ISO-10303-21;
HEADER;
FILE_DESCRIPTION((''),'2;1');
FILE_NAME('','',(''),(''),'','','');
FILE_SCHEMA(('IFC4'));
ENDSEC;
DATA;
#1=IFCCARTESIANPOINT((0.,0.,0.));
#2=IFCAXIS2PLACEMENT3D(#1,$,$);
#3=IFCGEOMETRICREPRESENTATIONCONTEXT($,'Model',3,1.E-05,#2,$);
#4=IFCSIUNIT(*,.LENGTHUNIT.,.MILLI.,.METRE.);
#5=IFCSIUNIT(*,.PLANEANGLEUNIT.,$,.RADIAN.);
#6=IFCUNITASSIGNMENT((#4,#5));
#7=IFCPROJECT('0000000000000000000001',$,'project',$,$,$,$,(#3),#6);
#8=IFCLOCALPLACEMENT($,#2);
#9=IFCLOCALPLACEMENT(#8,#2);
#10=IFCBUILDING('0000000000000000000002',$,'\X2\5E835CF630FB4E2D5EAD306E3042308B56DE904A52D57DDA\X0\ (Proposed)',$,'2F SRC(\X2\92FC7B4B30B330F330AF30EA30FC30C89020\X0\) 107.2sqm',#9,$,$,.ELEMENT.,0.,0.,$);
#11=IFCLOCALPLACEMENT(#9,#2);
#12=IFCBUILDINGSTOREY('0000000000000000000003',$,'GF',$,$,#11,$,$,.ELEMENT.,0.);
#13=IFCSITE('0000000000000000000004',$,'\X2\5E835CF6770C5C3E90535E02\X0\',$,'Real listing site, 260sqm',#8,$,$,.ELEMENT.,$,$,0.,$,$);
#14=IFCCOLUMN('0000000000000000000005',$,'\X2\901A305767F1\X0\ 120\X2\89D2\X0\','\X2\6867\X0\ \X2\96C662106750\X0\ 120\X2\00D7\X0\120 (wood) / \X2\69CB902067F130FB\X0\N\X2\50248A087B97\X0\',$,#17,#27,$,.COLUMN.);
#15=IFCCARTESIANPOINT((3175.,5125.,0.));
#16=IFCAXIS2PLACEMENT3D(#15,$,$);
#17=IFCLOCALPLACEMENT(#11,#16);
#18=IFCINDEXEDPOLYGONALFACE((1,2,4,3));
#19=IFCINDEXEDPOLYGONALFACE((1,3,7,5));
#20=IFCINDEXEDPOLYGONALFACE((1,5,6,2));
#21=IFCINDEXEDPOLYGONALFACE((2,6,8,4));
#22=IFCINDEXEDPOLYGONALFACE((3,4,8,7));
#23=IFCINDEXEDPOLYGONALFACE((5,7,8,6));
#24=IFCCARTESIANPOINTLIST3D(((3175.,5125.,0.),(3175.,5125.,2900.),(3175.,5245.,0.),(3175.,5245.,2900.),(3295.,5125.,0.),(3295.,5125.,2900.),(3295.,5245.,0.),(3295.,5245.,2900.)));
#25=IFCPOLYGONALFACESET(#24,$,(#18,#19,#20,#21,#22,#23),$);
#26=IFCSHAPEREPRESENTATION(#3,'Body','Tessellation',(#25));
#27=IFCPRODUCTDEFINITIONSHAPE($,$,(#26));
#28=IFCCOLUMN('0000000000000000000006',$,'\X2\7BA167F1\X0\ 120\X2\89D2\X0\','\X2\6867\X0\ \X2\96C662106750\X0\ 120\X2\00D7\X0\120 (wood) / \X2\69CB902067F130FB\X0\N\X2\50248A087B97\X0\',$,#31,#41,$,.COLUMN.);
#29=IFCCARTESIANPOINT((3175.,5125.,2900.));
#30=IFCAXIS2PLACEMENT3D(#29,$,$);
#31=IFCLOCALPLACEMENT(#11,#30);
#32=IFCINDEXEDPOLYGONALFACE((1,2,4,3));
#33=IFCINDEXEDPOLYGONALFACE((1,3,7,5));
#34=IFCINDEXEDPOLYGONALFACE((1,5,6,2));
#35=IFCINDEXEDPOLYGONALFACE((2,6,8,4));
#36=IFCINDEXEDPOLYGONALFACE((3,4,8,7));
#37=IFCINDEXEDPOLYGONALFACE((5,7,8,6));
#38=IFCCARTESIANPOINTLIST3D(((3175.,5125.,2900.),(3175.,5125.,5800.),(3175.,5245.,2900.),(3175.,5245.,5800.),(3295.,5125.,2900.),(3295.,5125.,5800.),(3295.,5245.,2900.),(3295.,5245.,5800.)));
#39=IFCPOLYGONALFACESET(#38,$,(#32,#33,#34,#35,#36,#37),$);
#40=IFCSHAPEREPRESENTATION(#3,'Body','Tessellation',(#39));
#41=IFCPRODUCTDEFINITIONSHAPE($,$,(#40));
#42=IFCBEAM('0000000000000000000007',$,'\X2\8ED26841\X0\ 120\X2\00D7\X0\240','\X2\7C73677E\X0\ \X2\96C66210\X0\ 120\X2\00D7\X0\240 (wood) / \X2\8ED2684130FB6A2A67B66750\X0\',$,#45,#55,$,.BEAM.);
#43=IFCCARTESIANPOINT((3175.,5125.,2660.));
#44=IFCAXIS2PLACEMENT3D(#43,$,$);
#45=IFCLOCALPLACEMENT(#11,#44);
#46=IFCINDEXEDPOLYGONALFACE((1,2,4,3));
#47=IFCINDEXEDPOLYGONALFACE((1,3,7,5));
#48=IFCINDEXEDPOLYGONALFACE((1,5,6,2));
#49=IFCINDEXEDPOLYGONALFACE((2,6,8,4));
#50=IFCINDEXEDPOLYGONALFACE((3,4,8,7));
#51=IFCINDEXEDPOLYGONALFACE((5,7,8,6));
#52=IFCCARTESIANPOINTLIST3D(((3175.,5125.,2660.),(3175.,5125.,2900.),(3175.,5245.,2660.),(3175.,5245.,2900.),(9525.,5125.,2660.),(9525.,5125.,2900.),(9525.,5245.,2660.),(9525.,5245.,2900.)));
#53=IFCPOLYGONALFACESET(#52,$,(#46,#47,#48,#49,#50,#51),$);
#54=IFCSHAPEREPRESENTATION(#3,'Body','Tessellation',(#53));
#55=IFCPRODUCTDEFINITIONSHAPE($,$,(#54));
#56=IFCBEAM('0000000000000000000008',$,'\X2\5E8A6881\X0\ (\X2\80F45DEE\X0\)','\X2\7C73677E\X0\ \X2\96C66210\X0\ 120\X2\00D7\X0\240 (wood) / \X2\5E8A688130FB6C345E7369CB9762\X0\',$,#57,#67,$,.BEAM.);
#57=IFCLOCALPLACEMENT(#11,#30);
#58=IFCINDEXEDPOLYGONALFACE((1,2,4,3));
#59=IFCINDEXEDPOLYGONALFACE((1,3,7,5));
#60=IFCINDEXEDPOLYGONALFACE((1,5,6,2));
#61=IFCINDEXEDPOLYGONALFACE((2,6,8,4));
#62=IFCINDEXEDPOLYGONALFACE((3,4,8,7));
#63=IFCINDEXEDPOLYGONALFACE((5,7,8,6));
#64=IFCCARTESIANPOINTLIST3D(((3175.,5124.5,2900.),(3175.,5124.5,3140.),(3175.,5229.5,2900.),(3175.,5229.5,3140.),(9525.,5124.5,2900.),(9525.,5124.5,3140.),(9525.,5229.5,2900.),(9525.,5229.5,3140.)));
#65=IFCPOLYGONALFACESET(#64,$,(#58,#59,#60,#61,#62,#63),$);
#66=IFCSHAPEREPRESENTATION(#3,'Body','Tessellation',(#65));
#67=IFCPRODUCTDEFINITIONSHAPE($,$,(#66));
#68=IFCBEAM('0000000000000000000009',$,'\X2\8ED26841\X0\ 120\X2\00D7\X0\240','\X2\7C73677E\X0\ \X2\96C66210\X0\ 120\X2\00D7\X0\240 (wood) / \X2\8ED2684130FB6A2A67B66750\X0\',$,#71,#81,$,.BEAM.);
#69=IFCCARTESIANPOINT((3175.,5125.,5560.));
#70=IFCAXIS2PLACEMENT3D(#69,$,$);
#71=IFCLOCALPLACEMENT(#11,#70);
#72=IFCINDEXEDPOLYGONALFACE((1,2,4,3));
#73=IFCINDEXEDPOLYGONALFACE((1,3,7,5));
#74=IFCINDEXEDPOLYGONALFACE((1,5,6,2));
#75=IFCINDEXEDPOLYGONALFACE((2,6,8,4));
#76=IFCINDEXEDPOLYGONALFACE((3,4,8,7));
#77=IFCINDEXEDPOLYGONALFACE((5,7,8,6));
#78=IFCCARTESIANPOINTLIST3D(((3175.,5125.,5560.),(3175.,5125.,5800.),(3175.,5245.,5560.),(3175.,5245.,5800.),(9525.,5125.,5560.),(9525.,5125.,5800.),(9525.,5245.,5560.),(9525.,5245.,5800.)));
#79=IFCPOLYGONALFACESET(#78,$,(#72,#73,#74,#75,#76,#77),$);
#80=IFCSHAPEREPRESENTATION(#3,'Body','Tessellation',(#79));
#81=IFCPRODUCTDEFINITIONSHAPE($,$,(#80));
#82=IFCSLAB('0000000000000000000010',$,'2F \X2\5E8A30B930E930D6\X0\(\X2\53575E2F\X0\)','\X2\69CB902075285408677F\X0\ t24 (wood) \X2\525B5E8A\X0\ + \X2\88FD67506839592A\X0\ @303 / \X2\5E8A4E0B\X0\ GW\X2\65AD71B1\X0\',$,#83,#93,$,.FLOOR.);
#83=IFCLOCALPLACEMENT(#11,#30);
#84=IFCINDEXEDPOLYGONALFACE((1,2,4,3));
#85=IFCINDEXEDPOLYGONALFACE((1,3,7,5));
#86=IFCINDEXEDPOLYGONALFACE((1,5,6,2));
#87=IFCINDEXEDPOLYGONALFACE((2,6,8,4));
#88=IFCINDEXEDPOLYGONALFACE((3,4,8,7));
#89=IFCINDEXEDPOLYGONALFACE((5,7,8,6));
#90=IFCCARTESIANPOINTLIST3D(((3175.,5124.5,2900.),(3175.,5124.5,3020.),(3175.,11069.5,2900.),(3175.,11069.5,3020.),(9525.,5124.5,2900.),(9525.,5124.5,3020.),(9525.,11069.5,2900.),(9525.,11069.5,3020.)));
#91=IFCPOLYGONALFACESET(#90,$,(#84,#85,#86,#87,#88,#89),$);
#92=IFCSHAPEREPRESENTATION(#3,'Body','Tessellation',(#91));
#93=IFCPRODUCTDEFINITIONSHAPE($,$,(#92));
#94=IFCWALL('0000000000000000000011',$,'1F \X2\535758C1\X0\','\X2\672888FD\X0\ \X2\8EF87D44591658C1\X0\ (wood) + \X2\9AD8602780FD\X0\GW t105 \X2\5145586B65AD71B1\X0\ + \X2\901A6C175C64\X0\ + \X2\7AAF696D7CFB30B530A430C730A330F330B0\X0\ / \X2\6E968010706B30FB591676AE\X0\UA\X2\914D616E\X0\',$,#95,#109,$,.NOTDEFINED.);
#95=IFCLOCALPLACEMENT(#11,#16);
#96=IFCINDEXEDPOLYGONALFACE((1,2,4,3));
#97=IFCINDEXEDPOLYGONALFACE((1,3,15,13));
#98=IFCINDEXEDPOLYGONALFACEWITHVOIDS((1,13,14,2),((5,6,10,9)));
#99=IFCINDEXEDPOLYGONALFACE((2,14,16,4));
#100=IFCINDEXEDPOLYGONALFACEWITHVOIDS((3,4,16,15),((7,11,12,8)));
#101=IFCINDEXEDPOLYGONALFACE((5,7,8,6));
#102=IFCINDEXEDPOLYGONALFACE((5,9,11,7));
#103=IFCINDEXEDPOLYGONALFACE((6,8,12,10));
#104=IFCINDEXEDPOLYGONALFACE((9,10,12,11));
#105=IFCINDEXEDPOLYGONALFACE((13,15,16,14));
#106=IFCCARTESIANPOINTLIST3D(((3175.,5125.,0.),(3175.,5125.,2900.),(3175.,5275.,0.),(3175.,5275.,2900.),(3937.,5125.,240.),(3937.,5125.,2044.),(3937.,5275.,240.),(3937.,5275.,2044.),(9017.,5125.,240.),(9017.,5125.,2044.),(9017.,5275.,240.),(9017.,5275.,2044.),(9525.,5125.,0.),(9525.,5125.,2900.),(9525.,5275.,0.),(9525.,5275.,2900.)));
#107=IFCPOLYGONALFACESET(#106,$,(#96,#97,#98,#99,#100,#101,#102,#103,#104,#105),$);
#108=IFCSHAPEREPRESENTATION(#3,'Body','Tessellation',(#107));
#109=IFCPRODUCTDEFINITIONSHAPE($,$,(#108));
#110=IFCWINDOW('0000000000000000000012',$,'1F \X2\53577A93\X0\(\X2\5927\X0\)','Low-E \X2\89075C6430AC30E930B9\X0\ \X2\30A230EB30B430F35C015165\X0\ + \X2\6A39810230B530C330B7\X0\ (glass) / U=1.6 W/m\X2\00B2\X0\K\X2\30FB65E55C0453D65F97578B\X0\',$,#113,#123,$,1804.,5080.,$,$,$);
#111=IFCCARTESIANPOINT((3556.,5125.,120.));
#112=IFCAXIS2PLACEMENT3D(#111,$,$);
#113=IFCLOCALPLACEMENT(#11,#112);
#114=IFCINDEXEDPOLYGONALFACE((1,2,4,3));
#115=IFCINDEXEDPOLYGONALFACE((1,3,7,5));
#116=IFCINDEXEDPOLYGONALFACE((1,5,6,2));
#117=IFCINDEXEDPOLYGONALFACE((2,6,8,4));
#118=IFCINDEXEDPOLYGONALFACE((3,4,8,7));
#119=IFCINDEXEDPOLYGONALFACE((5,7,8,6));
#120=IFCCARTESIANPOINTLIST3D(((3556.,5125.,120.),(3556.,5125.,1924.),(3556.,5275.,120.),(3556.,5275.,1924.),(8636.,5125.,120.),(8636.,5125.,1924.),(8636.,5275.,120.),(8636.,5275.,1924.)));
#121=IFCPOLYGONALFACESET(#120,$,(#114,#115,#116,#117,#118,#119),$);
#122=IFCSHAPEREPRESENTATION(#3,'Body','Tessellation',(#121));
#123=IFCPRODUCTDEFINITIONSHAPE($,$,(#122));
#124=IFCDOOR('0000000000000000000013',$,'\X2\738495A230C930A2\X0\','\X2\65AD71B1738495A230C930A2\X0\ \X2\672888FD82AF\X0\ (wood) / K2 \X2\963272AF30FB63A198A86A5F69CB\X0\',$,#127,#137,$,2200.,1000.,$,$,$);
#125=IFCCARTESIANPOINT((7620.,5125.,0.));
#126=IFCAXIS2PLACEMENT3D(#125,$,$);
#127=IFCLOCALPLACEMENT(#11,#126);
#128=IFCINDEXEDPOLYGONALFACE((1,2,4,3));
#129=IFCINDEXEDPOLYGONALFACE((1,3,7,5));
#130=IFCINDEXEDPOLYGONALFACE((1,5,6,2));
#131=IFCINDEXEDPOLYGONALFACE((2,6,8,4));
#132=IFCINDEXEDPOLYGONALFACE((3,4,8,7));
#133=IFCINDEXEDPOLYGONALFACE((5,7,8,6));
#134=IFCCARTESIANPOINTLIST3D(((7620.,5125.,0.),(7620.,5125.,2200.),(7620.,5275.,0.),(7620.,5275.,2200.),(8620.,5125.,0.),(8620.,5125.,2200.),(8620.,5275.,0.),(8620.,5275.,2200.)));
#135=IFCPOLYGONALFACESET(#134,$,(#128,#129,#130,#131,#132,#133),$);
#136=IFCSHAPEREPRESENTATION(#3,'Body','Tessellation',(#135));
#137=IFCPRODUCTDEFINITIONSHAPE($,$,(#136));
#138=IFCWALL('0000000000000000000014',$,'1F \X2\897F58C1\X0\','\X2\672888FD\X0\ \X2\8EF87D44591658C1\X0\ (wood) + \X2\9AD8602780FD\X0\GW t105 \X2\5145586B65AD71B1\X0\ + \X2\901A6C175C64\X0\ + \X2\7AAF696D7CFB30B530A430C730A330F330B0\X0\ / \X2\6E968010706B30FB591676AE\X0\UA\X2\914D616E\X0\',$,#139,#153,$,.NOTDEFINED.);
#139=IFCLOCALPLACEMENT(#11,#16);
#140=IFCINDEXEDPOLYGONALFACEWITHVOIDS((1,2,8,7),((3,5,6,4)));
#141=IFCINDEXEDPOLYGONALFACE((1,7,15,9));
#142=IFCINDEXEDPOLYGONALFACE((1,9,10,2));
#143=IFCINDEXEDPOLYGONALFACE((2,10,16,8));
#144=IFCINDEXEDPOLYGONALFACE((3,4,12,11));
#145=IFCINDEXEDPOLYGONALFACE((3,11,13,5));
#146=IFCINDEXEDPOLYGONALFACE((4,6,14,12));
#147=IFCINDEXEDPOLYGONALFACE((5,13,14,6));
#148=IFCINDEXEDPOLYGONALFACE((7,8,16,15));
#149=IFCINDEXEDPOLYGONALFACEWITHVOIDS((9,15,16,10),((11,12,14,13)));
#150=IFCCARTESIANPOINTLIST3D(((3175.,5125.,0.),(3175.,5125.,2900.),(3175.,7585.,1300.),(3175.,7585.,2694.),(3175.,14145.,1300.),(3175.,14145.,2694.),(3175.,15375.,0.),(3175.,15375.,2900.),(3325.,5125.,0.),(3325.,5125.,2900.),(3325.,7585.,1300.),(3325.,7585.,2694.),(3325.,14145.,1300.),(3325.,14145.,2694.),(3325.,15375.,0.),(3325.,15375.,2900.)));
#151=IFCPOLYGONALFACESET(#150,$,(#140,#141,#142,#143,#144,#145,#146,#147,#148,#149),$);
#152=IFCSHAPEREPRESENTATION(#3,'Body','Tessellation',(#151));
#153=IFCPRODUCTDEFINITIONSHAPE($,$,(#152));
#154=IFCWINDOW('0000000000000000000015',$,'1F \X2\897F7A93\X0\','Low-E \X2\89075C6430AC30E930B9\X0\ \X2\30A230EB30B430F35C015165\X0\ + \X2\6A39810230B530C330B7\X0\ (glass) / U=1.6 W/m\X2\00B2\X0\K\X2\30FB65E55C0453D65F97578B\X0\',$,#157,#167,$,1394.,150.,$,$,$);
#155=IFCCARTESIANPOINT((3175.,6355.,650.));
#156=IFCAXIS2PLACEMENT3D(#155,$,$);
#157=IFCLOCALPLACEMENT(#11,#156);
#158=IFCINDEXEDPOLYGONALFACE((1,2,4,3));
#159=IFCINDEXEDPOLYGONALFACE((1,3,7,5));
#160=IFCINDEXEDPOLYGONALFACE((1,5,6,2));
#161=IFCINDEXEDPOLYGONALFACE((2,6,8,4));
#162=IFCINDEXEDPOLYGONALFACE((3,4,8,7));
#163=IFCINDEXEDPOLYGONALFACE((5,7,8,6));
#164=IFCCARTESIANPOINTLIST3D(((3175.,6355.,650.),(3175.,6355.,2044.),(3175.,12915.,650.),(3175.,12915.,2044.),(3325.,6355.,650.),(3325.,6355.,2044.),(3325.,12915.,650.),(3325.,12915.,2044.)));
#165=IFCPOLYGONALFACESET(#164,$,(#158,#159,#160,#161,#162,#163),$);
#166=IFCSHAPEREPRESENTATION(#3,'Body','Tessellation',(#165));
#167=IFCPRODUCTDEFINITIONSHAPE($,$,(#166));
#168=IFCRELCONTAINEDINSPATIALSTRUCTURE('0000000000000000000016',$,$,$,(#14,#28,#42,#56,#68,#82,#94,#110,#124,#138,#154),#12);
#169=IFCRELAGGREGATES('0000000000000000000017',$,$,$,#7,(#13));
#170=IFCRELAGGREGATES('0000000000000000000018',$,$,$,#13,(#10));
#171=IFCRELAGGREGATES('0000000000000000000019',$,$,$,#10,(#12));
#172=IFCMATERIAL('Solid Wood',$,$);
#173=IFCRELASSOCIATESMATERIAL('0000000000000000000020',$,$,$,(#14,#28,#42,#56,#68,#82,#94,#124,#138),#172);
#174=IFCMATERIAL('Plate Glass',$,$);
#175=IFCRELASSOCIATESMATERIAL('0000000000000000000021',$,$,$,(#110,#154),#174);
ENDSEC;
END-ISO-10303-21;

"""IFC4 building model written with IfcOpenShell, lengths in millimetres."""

from ifc_helpers import new_model, si_unit, frame, frame_2d, origin, place, context, project, spatial, rectangle, extrude, material, element, fill, save


model = new_model("IFC4")

# Units and contexts
model_context = context("Model", 3, precision=1e-05, world=origin())
ifc_project = project(units=[si_unit("LENGTHUNIT", "METRE", prefix="MILLI"), si_unit("PLANEANGLEUNIT", "RADIAN")], contexts=[model_context])

# Site, building, storey
site_placement = place(None, origin())
site = spatial("IfcSite", under=ifc_project, at=site_placement, Name="広島県尾道市", ObjectType="Real listing site, 260sqm", CompositionType="ELEMENT", RefElevation=0.0)
building_placement = place(site_placement, origin())
building = spatial("IfcBuilding", under=site, at=building_placement, Name="広島・中庭のある回遊動線 (Proposed)", ObjectType="2F SRC(鋼筋コンクリート造) 107.2sqm", CompositionType="ELEMENT", ElevationOfRefHeight=0.0, ElevationOfTerrain=0.0)
storey_placement = place(building_placement, origin())
storey = spatial("IfcBuildingStorey", under=building, at=storey_placement, Name="GF", CompositionType="ELEMENT", Elevation=0.0)

# Columns
ifc_material_1 = material(Name="Solid Wood")
column_1_placement = place(storey_placement, frame((3175.0, 5125.0, 0.0)))
element("IfcColumn", 1, at=column_1_placement, inside=storey, material=ifc_material_1, Name="通し柱 120角", Description="桧 集成材 120×120 (wood) / 構造柱・N値計算", PredefinedType="COLUMN", context=model_context, shape_type="SweptSolid", body=[
    extrude(rectangle(XDim=120.0, YDim=120.0, at=frame_2d((60.0, 60.0))), frame((3175.0, 5125.0, 0.0)), (0.0, 0.0, 1.0), 2900.0),
])
column_2_placement = place(storey_placement, frame((3175.0, 5125.0, 2900.0)))
element("IfcColumn", 2, at=column_2_placement, inside=storey, material=ifc_material_1, Name="管柱 120角", Description="桧 集成材 120×120 (wood) / 構造柱・N値計算", PredefinedType="COLUMN", context=model_context, shape_type="SweptSolid", body=[
    extrude(rectangle(XDim=120.0, YDim=120.0, at=frame_2d((60.0, 60.0))), frame((3175.0, 5125.0, 2900.0)), (0.0, 0.0, 1.0), 2900.0),
])

# Beams
beam_1_placement = place(storey_placement, frame((3175.0, 5125.0, 2660.0)))
element("IfcBeam", 3, at=beam_1_placement, inside=storey, material=ifc_material_1, Name="軒桁 120×240", Description="米松 集成 120×240 (wood) / 軒桁・横架材", PredefinedType="BEAM", context=model_context, shape_type="SweptSolid", body=[
    extrude(rectangle(XDim=6350.0, YDim=120.0, at=frame_2d((3175.0, 60.0))), frame((3175.0, 5125.0, 2660.0)), (0.0, 0.0, 1.0), 240.0),
])
beam_2_placement = place(storey_placement, frame((3175.0, 5125.0, 2900.0)))
element("IfcBeam", 4, at=beam_2_placement, inside=storey, material=ifc_material_1, Name="床梁 (胴差)", Description="米松 集成 120×240 (wood) / 床梁・水平構面", PredefinedType="BEAM", context=model_context, shape_type="SweptSolid", body=[
    extrude(rectangle(XDim=6350.0, YDim=105.0, at=frame_2d((3175.0, 52.0))), frame((3175.0, 5125.0, 2900.0)), (0.0, 0.0, 1.0), 240.0),
])
beam_3_placement = place(storey_placement, frame((3175.0, 5125.0, 5560.0)))
element("IfcBeam", 5, at=beam_3_placement, inside=storey, material=ifc_material_1, Name="軒桁 120×240", Description="米松 集成 120×240 (wood) / 軒桁・横架材", PredefinedType="BEAM", context=model_context, shape_type="SweptSolid", body=[
    extrude(rectangle(XDim=6350.0, YDim=120.0, at=frame_2d((3175.0, 60.0))), frame((3175.0, 5125.0, 5560.0)), (0.0, 0.0, 1.0), 240.0),
])

# Slab
slab_1_placement = place(storey_placement, frame((3175.0, 5125.0, 2900.0)))
element("IfcSlab", 6, at=slab_1_placement, inside=storey, material=ifc_material_1, Name="2F 床スラブ(南帯)", Description="構造用合板 t24 (wood) 剛床 + 製材根太 @303 / 床下 GW断熱", PredefinedType="FLOOR", context=model_context, shape_type="SweptSolid", body=[
    extrude(rectangle(XDim=6350.0, YDim=5945.0, at=frame_2d((3175.0, 2972.0))), frame((3175.0, 5125.0, 2900.0)), (0.0, 0.0, 1.0), 120.0),
])

# Wall, openings, window, door
wall_1_placement = place(storey_placement, frame((3175.0, 5125.0, 0.0)))
wall_1 = element("IfcWall", 7, at=wall_1_placement, inside=storey, material=ifc_material_1, Name="1F 南壁", Description="木製 軸組外壁 (wood) + 高性能GW t105 充填断熱 + 通気層 + 窯業系サイディング / 準耐火・外皮UA配慮", PredefinedType="NOTDEFINED", context=model_context, shape_type="SweptSolid", body=[
    extrude(rectangle(XDim=6350.0, YDim=150.0, at=frame_2d((3175.0, 75.0))), frame((3175.0, 5125.0, 0.0)), (0.0, 0.0, 1.0), 2900.0),
])
opening_1_placement = place(storey_placement, frame((3556.0, 5125.0, 120.0)))
opening_1 = element("IfcOpeningElement", 8, at=opening_1_placement, cuts=wall_1, PredefinedType="NOTDEFINED", context=model_context, shape_type="SweptSolid", body=[
    extrude(rectangle(XDim=5080.0, YDim=150.0, at=frame_2d((2540.0, 75.0))), frame((3556.0, 5125.0, 120.0)), (0.0, 0.0, 1.0), 1804.0),
])
opening_2_placement = place(storey_placement, frame((7620.0, 5125.0, 0.0)))
opening_2 = element("IfcOpeningElement", 9, at=opening_2_placement, cuts=wall_1, PredefinedType="NOTDEFINED", context=model_context, shape_type="SweptSolid", body=[
    extrude(rectangle(XDim=1000.0, YDim=150.0, at=frame_2d((500.0, 75.0))), frame((7620.0, 5125.0, 0.0)), (0.0, 0.0, 1.0), 2200.0),
])
ifc_material_2 = material(Name="Plate Glass")
window_1_placement = place(storey_placement, frame((3556.0, 5125.0, 120.0)))
window_1 = element("IfcWindow", 10, at=window_1_placement, inside=storey, material=ifc_material_2, Name="1F 南窓(大)", Description="Low-E 複層ガラス アルゴン封入 + 樹脂サッシ (glass) / U=1.6 W/m²K・日射取得型", OverallHeight=1804.0, OverallWidth=5080.0, context=model_context, shape_type="SweptSolid", body=[
    extrude(rectangle(XDim=5080.0, YDim=150.0, at=frame_2d((2540.0, 75.0))), frame((3556.0, 5125.0, 120.0)), (0.0, 0.0, 1.0), 1804.0),
])
fill(opening_1, window_1)
door_placement = place(storey_placement, frame((7620.0, 5125.0, 0.0)))
door = element("IfcDoor", 11, at=door_placement, inside=storey, material=ifc_material_1, Name="玄関ドア", Description="断熱玄関ドア 木製芯 (wood) / K2 防犯・採風機構", OverallHeight=2200.0, OverallWidth=1000.0, context=model_context, shape_type="SweptSolid", body=[
    extrude(rectangle(XDim=1000.0, YDim=150.0, at=frame_2d((500.0, 75.0))), frame((7620.0, 5125.0, 0.0)), (0.0, 0.0, 1.0), 2200.0),
])
fill(opening_2, door)

# Wall, opening, window
wall_2_placement = place(storey_placement, frame((3175.0, 5125.0, 0.0)))
wall_2 = element("IfcWall", 12, at=wall_2_placement, inside=storey, material=ifc_material_1, Name="1F 西壁", Description="木製 軸組外壁 (wood) + 高性能GW t105 充填断熱 + 通気層 + 窯業系サイディング / 準耐火・外皮UA配慮", PredefinedType="NOTDEFINED", context=model_context, shape_type="SweptSolid", body=[
    extrude(rectangle(XDim=150.0, YDim=10250.0, at=frame_2d((75.0, 5125.0))), frame((3175.0, 5125.0, 0.0)), (0.0, 0.0, 1.0), 2900.0),
])
opening_3_placement = place(storey_placement, frame((3175.0, 6355.0, 650.0)))
opening_3 = element("IfcOpeningElement", 13, at=opening_3_placement, cuts=wall_2, PredefinedType="NOTDEFINED", context=model_context, shape_type="SweptSolid", body=[
    extrude(rectangle(XDim=150.0, YDim=6560.0, at=frame_2d((75.0, 3280.0))), frame((3175.0, 6355.0, 650.0)), (0.0, 0.0, 1.0), 1394.0),
])
window_2_placement = place(storey_placement, frame((3175.0, 6355.0, 650.0)))
window_2 = element("IfcWindow", 14, at=window_2_placement, inside=storey, material=ifc_material_2, Name="1F 西窓", Description="Low-E 複層ガラス アルゴン封入 + 樹脂サッシ (glass) / U=1.6 W/m²K・日射取得型", OverallHeight=1394.0, OverallWidth=150.0, context=model_context, shape_type="SweptSolid", body=[
    extrude(rectangle(XDim=150.0, YDim=6560.0, at=frame_2d((75.0, 3280.0))), frame((3175.0, 6355.0, 650.0)), (0.0, 0.0, 1.0), 1394.0),
])
fill(opening_3, window_2)

save(model, "model.ifc")
